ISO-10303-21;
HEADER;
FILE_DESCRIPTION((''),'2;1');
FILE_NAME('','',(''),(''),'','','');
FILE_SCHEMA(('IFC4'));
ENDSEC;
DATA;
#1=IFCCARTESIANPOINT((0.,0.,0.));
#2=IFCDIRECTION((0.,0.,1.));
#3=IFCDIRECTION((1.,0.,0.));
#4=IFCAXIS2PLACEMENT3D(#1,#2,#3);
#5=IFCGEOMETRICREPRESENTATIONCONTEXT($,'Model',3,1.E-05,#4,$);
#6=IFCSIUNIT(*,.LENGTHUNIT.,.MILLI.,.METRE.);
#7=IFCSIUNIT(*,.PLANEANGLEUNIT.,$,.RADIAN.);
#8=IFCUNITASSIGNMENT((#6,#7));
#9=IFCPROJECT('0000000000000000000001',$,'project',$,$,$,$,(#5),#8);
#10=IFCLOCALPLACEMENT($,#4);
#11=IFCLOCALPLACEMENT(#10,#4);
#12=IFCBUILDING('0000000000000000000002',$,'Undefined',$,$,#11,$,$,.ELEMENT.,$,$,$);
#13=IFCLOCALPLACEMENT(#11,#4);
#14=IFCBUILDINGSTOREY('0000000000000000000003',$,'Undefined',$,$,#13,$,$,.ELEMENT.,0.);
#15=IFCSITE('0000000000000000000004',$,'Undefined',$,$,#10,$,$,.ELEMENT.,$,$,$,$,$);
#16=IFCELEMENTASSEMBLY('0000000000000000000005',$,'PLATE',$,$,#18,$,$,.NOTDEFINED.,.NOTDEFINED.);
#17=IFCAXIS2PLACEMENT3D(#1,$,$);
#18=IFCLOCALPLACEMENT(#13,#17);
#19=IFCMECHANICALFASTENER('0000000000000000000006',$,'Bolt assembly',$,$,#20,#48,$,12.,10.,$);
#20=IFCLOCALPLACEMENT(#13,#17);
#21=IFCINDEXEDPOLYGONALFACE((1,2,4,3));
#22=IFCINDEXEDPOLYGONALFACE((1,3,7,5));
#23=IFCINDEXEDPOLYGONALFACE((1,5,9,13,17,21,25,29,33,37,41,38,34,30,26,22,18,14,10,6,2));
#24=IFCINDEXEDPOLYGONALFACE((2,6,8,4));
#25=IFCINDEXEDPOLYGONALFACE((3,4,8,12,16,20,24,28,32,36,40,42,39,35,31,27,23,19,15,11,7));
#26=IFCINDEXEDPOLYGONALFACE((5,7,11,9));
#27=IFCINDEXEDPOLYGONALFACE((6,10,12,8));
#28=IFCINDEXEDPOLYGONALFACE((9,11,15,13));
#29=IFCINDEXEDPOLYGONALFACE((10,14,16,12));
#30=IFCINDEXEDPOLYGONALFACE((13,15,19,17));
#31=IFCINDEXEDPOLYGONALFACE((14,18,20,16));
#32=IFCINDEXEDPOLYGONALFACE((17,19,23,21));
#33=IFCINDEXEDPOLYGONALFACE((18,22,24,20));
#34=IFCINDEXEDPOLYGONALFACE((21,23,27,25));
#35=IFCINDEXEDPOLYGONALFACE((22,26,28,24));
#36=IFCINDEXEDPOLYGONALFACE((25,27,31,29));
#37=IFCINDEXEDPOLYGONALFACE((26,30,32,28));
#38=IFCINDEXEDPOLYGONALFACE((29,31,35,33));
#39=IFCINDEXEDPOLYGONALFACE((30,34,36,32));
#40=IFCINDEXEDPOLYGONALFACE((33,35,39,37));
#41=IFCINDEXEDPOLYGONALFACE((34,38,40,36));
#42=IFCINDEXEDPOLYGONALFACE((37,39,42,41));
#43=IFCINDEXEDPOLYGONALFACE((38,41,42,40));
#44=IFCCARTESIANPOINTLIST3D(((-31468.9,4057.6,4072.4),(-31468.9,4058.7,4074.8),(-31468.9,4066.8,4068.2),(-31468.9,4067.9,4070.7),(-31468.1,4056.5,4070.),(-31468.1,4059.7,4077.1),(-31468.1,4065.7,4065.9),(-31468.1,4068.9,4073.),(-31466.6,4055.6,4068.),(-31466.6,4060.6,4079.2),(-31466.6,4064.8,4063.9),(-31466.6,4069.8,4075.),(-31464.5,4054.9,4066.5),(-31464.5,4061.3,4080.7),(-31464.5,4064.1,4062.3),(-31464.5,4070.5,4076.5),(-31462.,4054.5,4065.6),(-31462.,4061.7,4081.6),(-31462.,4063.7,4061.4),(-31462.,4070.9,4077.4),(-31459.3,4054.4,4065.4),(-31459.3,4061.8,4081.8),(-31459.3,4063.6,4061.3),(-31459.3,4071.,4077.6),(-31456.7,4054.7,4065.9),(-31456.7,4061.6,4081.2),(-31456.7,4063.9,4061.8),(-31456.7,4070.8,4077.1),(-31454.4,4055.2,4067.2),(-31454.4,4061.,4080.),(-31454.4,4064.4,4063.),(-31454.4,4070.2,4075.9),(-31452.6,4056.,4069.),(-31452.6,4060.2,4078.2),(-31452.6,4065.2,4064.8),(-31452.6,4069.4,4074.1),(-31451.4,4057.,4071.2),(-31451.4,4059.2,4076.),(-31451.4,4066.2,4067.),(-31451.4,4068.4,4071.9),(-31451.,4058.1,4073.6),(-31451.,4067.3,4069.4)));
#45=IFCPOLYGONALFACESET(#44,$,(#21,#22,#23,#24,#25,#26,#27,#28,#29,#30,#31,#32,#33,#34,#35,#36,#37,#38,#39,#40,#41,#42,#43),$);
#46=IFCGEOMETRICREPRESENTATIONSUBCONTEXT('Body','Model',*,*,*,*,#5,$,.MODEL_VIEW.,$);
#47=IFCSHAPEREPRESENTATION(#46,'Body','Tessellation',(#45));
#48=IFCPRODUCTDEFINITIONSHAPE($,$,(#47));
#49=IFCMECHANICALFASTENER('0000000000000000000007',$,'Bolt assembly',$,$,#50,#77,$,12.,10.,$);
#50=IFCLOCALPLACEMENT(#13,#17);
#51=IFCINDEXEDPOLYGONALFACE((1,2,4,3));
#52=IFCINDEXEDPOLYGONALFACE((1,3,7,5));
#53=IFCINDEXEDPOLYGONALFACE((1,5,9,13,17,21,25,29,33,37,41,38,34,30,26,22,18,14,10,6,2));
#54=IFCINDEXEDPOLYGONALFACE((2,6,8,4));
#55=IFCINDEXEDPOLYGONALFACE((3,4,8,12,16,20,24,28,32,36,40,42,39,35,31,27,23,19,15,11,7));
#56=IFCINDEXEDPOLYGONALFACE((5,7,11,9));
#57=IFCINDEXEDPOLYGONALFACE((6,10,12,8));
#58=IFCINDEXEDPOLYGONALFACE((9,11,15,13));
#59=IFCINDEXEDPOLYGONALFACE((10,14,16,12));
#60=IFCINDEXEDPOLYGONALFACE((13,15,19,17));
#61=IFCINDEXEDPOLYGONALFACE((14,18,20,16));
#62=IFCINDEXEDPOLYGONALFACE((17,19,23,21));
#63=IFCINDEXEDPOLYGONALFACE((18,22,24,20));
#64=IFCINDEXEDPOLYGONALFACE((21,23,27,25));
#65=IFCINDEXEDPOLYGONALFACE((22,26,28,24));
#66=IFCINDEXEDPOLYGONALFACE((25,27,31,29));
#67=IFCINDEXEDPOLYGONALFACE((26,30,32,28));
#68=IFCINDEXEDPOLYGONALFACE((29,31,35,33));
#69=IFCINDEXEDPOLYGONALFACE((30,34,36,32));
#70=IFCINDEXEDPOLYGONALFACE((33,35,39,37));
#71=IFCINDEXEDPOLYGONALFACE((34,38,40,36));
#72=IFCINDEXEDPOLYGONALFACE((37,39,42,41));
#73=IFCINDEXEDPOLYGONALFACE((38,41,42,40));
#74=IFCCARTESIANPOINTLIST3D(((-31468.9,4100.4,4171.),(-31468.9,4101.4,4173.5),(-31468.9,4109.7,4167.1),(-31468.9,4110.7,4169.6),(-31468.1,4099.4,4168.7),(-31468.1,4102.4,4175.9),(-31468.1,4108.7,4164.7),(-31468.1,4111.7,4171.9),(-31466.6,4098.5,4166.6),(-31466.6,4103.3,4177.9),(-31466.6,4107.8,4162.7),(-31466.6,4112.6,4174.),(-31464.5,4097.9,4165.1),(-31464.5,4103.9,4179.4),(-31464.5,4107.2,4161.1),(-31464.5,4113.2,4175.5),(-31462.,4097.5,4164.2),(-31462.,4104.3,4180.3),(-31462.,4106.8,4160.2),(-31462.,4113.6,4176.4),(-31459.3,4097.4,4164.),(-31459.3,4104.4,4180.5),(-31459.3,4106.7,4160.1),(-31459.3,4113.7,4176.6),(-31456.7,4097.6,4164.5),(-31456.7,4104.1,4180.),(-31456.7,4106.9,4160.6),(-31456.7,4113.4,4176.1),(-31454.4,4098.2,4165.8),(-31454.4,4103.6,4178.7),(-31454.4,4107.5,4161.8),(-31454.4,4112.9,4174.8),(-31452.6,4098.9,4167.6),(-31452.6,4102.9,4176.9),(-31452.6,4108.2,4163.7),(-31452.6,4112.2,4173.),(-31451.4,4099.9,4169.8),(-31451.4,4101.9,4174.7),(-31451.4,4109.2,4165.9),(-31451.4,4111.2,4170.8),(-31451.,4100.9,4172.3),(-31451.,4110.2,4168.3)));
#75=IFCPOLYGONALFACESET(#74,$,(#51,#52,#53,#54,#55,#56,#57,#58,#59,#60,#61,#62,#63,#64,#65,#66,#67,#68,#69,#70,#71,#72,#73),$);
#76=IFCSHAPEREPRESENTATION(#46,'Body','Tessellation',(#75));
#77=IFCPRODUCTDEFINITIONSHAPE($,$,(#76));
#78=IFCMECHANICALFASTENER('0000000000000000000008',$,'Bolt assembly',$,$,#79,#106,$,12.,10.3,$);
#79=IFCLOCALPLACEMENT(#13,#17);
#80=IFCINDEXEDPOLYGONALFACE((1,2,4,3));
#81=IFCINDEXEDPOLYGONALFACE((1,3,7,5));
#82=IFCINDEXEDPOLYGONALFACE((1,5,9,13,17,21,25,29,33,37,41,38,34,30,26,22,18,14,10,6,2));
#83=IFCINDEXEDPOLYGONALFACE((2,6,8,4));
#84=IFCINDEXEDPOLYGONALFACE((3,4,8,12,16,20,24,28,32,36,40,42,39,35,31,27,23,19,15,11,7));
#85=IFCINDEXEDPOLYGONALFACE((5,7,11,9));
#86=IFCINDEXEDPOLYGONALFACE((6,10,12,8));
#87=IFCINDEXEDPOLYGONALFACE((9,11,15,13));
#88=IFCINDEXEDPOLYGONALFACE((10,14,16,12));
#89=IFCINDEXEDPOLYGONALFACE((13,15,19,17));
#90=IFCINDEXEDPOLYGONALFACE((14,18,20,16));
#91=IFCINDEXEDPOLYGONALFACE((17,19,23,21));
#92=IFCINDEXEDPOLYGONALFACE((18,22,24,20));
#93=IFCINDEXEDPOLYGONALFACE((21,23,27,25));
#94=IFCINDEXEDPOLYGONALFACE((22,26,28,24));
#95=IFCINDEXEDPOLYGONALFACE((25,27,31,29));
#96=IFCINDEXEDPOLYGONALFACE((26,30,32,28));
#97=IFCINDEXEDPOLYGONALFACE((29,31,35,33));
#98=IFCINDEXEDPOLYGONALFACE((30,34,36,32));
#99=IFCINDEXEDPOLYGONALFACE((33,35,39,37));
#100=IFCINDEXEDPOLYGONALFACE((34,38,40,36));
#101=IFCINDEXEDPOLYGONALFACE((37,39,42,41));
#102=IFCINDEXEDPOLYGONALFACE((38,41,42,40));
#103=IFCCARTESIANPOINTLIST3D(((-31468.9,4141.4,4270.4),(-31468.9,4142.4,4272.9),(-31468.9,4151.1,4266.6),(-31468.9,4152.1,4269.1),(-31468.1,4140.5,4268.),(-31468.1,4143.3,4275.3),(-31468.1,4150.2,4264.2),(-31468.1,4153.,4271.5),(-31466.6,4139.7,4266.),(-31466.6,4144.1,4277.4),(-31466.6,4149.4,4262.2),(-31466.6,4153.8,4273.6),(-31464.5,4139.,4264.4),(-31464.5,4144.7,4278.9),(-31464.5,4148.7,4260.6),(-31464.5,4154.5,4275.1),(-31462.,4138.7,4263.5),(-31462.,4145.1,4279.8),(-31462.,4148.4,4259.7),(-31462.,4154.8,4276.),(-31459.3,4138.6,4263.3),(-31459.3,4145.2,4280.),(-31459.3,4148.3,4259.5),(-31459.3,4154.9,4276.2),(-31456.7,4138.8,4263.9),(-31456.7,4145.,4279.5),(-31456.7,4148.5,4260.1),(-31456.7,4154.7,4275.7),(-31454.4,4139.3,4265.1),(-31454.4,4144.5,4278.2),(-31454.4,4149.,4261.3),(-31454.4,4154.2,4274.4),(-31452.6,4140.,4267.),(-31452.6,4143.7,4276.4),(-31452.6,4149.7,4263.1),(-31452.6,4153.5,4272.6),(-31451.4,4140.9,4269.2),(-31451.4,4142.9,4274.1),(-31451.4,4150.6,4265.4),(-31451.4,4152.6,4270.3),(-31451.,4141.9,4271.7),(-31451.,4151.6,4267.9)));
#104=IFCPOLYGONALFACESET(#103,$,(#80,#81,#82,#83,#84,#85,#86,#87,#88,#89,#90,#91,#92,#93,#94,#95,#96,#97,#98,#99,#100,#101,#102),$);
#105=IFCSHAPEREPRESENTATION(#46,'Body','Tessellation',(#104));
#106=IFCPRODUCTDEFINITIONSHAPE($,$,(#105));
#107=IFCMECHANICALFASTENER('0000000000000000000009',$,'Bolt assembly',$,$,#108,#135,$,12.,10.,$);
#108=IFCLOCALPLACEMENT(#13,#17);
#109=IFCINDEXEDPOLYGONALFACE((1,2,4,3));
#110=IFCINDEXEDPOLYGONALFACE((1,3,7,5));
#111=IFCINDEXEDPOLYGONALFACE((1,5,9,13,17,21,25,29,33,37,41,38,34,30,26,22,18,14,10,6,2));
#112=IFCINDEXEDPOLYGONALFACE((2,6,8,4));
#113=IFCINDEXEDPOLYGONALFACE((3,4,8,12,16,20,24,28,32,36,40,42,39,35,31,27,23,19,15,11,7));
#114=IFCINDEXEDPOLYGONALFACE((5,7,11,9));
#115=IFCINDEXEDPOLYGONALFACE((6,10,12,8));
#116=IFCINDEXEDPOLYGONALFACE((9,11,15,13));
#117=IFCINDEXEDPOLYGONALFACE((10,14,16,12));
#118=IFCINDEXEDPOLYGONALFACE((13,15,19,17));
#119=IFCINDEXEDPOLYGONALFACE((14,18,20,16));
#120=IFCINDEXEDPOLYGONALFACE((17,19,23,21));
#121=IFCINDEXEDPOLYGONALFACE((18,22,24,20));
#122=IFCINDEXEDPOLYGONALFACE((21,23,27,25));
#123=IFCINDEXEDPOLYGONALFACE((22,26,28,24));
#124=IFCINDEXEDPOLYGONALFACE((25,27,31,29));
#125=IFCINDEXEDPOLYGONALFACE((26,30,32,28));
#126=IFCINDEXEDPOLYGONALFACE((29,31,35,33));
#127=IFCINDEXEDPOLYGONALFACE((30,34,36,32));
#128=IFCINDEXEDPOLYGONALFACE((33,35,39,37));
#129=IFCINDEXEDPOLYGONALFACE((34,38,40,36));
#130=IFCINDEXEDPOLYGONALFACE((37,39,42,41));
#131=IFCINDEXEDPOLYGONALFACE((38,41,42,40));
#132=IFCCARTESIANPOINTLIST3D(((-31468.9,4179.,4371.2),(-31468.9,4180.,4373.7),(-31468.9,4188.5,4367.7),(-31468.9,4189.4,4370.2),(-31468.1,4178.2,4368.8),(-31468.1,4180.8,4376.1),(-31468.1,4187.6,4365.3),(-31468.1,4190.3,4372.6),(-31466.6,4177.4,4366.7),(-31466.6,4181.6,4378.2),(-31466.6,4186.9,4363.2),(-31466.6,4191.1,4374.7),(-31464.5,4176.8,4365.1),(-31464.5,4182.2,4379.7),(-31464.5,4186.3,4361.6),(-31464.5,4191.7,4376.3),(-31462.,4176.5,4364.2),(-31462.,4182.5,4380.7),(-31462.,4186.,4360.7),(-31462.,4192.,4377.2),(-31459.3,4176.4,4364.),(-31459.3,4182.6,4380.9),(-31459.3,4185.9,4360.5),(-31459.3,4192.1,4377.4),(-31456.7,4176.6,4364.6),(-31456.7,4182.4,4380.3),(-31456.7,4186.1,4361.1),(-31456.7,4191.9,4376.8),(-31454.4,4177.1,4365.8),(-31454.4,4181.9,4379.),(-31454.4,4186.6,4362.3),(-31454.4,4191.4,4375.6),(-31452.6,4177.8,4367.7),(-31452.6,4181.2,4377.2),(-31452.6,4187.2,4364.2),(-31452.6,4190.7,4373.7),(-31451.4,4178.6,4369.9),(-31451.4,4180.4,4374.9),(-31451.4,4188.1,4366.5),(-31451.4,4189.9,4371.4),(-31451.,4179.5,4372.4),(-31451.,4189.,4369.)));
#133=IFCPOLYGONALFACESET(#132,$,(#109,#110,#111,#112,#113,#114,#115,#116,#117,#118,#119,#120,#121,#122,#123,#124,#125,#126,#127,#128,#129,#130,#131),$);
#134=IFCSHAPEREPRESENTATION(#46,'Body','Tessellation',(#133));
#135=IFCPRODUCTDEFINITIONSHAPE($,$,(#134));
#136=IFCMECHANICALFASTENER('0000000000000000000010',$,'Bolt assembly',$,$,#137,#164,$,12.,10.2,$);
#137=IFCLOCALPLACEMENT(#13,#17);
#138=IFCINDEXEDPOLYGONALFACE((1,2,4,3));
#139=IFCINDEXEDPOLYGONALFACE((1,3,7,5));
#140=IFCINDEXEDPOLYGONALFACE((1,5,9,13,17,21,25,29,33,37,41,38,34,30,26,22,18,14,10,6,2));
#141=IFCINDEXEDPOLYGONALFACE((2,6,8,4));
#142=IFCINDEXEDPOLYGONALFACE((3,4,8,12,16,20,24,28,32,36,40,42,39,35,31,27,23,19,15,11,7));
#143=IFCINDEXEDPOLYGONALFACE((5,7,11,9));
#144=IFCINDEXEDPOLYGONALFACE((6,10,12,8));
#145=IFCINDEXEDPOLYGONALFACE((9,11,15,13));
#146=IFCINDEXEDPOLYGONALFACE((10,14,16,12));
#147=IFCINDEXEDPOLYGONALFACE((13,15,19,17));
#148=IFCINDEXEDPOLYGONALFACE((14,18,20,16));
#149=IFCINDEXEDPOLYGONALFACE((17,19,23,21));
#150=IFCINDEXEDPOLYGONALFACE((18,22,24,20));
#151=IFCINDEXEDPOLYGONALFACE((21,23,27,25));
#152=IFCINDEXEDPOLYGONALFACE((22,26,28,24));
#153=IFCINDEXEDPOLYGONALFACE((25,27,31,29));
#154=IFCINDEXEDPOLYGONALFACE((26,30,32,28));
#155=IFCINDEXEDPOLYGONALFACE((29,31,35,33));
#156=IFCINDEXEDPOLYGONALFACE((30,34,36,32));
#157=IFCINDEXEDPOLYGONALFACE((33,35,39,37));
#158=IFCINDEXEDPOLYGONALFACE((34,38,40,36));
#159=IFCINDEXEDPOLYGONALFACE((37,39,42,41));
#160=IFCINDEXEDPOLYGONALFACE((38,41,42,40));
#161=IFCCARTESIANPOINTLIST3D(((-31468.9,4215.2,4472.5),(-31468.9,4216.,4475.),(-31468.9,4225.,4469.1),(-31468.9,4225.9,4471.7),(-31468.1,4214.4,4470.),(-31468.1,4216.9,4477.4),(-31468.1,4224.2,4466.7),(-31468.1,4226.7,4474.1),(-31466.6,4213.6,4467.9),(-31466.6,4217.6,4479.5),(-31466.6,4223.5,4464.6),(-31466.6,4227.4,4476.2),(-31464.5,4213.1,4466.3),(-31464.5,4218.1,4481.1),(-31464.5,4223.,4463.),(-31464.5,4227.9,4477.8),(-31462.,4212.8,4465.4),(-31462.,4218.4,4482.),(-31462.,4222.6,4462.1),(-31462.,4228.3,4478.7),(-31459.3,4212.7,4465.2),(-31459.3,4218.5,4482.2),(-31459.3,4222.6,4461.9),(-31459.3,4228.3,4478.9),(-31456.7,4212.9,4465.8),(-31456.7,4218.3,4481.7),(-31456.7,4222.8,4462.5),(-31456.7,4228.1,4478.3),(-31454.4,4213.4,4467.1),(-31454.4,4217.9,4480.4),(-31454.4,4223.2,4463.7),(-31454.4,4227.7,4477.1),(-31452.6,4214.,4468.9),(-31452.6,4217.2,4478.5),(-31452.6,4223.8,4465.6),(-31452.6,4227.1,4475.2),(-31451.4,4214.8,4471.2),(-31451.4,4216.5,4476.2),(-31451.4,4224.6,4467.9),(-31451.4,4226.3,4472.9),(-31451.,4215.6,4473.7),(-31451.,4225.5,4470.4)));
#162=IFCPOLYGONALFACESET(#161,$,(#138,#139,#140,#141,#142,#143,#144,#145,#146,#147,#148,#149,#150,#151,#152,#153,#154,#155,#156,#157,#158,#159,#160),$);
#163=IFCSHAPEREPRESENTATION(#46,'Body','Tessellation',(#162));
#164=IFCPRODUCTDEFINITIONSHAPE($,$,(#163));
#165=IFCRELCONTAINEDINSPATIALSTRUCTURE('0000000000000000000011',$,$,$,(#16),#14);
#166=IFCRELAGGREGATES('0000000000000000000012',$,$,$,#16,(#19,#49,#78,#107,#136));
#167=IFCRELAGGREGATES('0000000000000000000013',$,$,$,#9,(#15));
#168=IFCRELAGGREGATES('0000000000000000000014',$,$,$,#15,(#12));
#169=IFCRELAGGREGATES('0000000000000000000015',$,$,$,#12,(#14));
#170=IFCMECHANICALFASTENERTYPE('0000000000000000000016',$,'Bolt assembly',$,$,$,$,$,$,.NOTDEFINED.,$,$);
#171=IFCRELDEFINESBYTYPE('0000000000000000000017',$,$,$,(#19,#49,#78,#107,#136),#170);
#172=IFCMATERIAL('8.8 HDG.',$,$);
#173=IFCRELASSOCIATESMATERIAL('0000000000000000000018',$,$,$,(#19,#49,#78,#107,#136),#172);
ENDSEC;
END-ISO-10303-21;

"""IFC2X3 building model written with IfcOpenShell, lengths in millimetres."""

from ifc_helpers import new_model, si_unit, frame, origin_with_axes, origin_2d_with_axis, place, context, subcontext, project, spatial, circle, extrude, source, transform, mapped, material, type_object, element, aggregate, save


model = new_model("IFC2X3")

# Units and contexts
model_context = context("Model", 3, precision=1e-05, world=origin_with_axes())
body_context = subcontext(model_context, "Body", "Model", "MODEL_VIEW")
ifc_project = project(units=[si_unit("LENGTHUNIT", "METRE", prefix="MILLI"), si_unit("PLANEANGLEUNIT", "RADIAN")], contexts=[model_context])

# Site, building, storey
site_placement = place(None, origin_with_axes())
site = spatial("IfcSite", under=ifc_project, at=site_placement, Name="Undefined", CompositionType="ELEMENT")
building_placement = place(site_placement, origin_with_axes())
building = spatial("IfcBuilding", under=site, at=building_placement, Name="Undefined", CompositionType="ELEMENT")
storey_placement = place(building_placement, origin_with_axes())
storey = spatial("IfcBuildingStorey", under=building, at=storey_placement, Name="Undefined", CompositionType="ELEMENT", Elevation=0.0)

# Element assembly, mechanical fasteners
assembly_placement = place(storey_placement, origin_with_axes())
assembly = element("IfcElementAssembly", 1, at=assembly_placement, inside=storey, Name="PLATE", AssemblyPlace="NOTDEFINED", PredefinedType="NOTDEFINED")
ifc_material_1 = material(Name="8.8 HDG.")
mechanical_fastener_type = type_object("IfcMechanicalFastenerType", Name="Bolt assembly")
shared_shape_1 = source(origin_with_axes(), body_context, "Body", "SweptSolid", [
    extrude(circle(Radius=9.0, at=origin_2d_with_axis()), frame((0.0, 0.7, 0.0), z_axis=(0.0, 1.0, 0.0), x_axis=(1.0, 0.0, 0.0)), (0.0, 0.0, 1.0), 10.1),
])
mechanical_fastener_1_placement = place(assembly_placement, frame((-31460.0, 4067.9, 4069.2), z_axis=(0.000001, -0.410413, -0.9119), x_axis=(1.0, 0.000001, 0.000001)))
mechanical_fastener_1 = element("IfcMechanicalFastener", 2, at=mechanical_fastener_1_placement, type_object=mechanical_fastener_type, material=ifc_material_1, Name="Bolt assembly", NominalDiameter=12.0, NominalLength=10.0, context=body_context, shape_type="MappedRepresentation", body=[
    mapped(shared_shape_1, transform((0.0, 0.0, 0.0))),
])
shared_shape_2 = source(origin_with_axes(), body_context, "Body", "SweptSolid", [
    extrude(circle(Radius=9.0, at=origin_2d_with_axis()), frame((0.0, 0.9, 0.0), z_axis=(0.0, 1.0, 0.0), x_axis=(1.0, 0.0, 0.0)), (0.0, 0.0, 1.0), 10.1),
])
mechanical_fastener_2_placement = place(assembly_placement, frame((-31460.0, 4111.0, 4168.0), z_axis=(0.000001, -0.388258, -0.921551), x_axis=(1.0, 0.000001, 0.000001)))
mechanical_fastener_2 = element("IfcMechanicalFastener", 3, at=mechanical_fastener_2_placement, type_object=mechanical_fastener_type, material=ifc_material_1, Name="Bolt assembly", NominalDiameter=12.0, NominalLength=10.0, context=body_context, shape_type="MappedRepresentation", body=[
    mapped(shared_shape_2, transform((0.0, 0.0, 0.0))),
])
shared_shape_3 = source(origin_with_axes(), body_context, "Body", "SweptSolid", [
    extrude(circle(Radius=9.0, at=origin_2d_with_axis()), frame((0.0, 0.0, 0.0), z_axis=(0.0, 1.0, 0.0), x_axis=(1.0, 0.0, 0.0)), (0.0, 0.0, 1.0), 10.4),
])
mechanical_fastener_3_placement = place(assembly_placement, frame((-31460.0, 4151.6, 4267.8), z_axis=(0.000001, -0.365877, -0.930663), x_axis=(1.0, 0.000001, 0.000001)))
mechanical_fastener_3 = element("IfcMechanicalFastener", 4, at=mechanical_fastener_3_placement, type_object=mechanical_fastener_type, material=ifc_material_1, Name="Bolt assembly", NominalDiameter=12.0, NominalLength=10.3, context=body_context, shape_type="MappedRepresentation", body=[
    mapped(shared_shape_3, transform((0.0, 0.0, 0.0))),
])
shared_shape_4 = source(origin_with_axes(), body_context, "Body", "SweptSolid", [
    extrude(circle(Radius=9.0, at=origin_2d_with_axis()), frame((0.0, 0.9, 0.0), z_axis=(0.0, 1.0, 0.0), x_axis=(1.0, 0.0, 0.0)), (0.0, 0.0, 1.0), 10.1),
])
mechanical_fastener_4_placement = place(assembly_placement, frame((-31460.0, 4189.9, 4368.6), z_axis=(0.000001, -0.343282, -0.939233), x_axis=(1.0, 0.000001, 0.000001)))
mechanical_fastener_4 = element("IfcMechanicalFastener", 5, at=mechanical_fastener_4_placement, type_object=mechanical_fastener_type, material=ifc_material_1, Name="Bolt assembly", NominalDiameter=12.0, NominalLength=10.0, context=body_context, shape_type="MappedRepresentation", body=[
    mapped(shared_shape_4, transform((0.0, 0.0, 0.0))),
])
shared_shape_5 = source(origin_with_axes(), body_context, "Body", "SweptSolid", [
    extrude(circle(Radius=9.0, at=origin_2d_with_axis()), frame((0.0, 0.2, 0.0), z_axis=(0.0, 1.0, 0.0), x_axis=(1.0, 0.0, 0.0)), (0.0, 0.0, 1.0), 10.4),
])
mechanical_fastener_5_placement = place(assembly_placement, frame((-31460.0, 4225.6, 4470.3), z_axis=(0.000001, -0.320486, -0.947253), x_axis=(1.0, 0.000001, 0.000001)))
mechanical_fastener_5 = element("IfcMechanicalFastener", 6, at=mechanical_fastener_5_placement, type_object=mechanical_fastener_type, material=ifc_material_1, Name="Bolt assembly", NominalDiameter=12.0, NominalLength=10.2, context=body_context, shape_type="MappedRepresentation", body=[
    mapped(shared_shape_5, transform((0.0, 0.0, 0.0))),
])
aggregate(assembly, [mechanical_fastener_1, mechanical_fastener_2, mechanical_fastener_3, mechanical_fastener_4, mechanical_fastener_5])

save(model, "model.ifc")
